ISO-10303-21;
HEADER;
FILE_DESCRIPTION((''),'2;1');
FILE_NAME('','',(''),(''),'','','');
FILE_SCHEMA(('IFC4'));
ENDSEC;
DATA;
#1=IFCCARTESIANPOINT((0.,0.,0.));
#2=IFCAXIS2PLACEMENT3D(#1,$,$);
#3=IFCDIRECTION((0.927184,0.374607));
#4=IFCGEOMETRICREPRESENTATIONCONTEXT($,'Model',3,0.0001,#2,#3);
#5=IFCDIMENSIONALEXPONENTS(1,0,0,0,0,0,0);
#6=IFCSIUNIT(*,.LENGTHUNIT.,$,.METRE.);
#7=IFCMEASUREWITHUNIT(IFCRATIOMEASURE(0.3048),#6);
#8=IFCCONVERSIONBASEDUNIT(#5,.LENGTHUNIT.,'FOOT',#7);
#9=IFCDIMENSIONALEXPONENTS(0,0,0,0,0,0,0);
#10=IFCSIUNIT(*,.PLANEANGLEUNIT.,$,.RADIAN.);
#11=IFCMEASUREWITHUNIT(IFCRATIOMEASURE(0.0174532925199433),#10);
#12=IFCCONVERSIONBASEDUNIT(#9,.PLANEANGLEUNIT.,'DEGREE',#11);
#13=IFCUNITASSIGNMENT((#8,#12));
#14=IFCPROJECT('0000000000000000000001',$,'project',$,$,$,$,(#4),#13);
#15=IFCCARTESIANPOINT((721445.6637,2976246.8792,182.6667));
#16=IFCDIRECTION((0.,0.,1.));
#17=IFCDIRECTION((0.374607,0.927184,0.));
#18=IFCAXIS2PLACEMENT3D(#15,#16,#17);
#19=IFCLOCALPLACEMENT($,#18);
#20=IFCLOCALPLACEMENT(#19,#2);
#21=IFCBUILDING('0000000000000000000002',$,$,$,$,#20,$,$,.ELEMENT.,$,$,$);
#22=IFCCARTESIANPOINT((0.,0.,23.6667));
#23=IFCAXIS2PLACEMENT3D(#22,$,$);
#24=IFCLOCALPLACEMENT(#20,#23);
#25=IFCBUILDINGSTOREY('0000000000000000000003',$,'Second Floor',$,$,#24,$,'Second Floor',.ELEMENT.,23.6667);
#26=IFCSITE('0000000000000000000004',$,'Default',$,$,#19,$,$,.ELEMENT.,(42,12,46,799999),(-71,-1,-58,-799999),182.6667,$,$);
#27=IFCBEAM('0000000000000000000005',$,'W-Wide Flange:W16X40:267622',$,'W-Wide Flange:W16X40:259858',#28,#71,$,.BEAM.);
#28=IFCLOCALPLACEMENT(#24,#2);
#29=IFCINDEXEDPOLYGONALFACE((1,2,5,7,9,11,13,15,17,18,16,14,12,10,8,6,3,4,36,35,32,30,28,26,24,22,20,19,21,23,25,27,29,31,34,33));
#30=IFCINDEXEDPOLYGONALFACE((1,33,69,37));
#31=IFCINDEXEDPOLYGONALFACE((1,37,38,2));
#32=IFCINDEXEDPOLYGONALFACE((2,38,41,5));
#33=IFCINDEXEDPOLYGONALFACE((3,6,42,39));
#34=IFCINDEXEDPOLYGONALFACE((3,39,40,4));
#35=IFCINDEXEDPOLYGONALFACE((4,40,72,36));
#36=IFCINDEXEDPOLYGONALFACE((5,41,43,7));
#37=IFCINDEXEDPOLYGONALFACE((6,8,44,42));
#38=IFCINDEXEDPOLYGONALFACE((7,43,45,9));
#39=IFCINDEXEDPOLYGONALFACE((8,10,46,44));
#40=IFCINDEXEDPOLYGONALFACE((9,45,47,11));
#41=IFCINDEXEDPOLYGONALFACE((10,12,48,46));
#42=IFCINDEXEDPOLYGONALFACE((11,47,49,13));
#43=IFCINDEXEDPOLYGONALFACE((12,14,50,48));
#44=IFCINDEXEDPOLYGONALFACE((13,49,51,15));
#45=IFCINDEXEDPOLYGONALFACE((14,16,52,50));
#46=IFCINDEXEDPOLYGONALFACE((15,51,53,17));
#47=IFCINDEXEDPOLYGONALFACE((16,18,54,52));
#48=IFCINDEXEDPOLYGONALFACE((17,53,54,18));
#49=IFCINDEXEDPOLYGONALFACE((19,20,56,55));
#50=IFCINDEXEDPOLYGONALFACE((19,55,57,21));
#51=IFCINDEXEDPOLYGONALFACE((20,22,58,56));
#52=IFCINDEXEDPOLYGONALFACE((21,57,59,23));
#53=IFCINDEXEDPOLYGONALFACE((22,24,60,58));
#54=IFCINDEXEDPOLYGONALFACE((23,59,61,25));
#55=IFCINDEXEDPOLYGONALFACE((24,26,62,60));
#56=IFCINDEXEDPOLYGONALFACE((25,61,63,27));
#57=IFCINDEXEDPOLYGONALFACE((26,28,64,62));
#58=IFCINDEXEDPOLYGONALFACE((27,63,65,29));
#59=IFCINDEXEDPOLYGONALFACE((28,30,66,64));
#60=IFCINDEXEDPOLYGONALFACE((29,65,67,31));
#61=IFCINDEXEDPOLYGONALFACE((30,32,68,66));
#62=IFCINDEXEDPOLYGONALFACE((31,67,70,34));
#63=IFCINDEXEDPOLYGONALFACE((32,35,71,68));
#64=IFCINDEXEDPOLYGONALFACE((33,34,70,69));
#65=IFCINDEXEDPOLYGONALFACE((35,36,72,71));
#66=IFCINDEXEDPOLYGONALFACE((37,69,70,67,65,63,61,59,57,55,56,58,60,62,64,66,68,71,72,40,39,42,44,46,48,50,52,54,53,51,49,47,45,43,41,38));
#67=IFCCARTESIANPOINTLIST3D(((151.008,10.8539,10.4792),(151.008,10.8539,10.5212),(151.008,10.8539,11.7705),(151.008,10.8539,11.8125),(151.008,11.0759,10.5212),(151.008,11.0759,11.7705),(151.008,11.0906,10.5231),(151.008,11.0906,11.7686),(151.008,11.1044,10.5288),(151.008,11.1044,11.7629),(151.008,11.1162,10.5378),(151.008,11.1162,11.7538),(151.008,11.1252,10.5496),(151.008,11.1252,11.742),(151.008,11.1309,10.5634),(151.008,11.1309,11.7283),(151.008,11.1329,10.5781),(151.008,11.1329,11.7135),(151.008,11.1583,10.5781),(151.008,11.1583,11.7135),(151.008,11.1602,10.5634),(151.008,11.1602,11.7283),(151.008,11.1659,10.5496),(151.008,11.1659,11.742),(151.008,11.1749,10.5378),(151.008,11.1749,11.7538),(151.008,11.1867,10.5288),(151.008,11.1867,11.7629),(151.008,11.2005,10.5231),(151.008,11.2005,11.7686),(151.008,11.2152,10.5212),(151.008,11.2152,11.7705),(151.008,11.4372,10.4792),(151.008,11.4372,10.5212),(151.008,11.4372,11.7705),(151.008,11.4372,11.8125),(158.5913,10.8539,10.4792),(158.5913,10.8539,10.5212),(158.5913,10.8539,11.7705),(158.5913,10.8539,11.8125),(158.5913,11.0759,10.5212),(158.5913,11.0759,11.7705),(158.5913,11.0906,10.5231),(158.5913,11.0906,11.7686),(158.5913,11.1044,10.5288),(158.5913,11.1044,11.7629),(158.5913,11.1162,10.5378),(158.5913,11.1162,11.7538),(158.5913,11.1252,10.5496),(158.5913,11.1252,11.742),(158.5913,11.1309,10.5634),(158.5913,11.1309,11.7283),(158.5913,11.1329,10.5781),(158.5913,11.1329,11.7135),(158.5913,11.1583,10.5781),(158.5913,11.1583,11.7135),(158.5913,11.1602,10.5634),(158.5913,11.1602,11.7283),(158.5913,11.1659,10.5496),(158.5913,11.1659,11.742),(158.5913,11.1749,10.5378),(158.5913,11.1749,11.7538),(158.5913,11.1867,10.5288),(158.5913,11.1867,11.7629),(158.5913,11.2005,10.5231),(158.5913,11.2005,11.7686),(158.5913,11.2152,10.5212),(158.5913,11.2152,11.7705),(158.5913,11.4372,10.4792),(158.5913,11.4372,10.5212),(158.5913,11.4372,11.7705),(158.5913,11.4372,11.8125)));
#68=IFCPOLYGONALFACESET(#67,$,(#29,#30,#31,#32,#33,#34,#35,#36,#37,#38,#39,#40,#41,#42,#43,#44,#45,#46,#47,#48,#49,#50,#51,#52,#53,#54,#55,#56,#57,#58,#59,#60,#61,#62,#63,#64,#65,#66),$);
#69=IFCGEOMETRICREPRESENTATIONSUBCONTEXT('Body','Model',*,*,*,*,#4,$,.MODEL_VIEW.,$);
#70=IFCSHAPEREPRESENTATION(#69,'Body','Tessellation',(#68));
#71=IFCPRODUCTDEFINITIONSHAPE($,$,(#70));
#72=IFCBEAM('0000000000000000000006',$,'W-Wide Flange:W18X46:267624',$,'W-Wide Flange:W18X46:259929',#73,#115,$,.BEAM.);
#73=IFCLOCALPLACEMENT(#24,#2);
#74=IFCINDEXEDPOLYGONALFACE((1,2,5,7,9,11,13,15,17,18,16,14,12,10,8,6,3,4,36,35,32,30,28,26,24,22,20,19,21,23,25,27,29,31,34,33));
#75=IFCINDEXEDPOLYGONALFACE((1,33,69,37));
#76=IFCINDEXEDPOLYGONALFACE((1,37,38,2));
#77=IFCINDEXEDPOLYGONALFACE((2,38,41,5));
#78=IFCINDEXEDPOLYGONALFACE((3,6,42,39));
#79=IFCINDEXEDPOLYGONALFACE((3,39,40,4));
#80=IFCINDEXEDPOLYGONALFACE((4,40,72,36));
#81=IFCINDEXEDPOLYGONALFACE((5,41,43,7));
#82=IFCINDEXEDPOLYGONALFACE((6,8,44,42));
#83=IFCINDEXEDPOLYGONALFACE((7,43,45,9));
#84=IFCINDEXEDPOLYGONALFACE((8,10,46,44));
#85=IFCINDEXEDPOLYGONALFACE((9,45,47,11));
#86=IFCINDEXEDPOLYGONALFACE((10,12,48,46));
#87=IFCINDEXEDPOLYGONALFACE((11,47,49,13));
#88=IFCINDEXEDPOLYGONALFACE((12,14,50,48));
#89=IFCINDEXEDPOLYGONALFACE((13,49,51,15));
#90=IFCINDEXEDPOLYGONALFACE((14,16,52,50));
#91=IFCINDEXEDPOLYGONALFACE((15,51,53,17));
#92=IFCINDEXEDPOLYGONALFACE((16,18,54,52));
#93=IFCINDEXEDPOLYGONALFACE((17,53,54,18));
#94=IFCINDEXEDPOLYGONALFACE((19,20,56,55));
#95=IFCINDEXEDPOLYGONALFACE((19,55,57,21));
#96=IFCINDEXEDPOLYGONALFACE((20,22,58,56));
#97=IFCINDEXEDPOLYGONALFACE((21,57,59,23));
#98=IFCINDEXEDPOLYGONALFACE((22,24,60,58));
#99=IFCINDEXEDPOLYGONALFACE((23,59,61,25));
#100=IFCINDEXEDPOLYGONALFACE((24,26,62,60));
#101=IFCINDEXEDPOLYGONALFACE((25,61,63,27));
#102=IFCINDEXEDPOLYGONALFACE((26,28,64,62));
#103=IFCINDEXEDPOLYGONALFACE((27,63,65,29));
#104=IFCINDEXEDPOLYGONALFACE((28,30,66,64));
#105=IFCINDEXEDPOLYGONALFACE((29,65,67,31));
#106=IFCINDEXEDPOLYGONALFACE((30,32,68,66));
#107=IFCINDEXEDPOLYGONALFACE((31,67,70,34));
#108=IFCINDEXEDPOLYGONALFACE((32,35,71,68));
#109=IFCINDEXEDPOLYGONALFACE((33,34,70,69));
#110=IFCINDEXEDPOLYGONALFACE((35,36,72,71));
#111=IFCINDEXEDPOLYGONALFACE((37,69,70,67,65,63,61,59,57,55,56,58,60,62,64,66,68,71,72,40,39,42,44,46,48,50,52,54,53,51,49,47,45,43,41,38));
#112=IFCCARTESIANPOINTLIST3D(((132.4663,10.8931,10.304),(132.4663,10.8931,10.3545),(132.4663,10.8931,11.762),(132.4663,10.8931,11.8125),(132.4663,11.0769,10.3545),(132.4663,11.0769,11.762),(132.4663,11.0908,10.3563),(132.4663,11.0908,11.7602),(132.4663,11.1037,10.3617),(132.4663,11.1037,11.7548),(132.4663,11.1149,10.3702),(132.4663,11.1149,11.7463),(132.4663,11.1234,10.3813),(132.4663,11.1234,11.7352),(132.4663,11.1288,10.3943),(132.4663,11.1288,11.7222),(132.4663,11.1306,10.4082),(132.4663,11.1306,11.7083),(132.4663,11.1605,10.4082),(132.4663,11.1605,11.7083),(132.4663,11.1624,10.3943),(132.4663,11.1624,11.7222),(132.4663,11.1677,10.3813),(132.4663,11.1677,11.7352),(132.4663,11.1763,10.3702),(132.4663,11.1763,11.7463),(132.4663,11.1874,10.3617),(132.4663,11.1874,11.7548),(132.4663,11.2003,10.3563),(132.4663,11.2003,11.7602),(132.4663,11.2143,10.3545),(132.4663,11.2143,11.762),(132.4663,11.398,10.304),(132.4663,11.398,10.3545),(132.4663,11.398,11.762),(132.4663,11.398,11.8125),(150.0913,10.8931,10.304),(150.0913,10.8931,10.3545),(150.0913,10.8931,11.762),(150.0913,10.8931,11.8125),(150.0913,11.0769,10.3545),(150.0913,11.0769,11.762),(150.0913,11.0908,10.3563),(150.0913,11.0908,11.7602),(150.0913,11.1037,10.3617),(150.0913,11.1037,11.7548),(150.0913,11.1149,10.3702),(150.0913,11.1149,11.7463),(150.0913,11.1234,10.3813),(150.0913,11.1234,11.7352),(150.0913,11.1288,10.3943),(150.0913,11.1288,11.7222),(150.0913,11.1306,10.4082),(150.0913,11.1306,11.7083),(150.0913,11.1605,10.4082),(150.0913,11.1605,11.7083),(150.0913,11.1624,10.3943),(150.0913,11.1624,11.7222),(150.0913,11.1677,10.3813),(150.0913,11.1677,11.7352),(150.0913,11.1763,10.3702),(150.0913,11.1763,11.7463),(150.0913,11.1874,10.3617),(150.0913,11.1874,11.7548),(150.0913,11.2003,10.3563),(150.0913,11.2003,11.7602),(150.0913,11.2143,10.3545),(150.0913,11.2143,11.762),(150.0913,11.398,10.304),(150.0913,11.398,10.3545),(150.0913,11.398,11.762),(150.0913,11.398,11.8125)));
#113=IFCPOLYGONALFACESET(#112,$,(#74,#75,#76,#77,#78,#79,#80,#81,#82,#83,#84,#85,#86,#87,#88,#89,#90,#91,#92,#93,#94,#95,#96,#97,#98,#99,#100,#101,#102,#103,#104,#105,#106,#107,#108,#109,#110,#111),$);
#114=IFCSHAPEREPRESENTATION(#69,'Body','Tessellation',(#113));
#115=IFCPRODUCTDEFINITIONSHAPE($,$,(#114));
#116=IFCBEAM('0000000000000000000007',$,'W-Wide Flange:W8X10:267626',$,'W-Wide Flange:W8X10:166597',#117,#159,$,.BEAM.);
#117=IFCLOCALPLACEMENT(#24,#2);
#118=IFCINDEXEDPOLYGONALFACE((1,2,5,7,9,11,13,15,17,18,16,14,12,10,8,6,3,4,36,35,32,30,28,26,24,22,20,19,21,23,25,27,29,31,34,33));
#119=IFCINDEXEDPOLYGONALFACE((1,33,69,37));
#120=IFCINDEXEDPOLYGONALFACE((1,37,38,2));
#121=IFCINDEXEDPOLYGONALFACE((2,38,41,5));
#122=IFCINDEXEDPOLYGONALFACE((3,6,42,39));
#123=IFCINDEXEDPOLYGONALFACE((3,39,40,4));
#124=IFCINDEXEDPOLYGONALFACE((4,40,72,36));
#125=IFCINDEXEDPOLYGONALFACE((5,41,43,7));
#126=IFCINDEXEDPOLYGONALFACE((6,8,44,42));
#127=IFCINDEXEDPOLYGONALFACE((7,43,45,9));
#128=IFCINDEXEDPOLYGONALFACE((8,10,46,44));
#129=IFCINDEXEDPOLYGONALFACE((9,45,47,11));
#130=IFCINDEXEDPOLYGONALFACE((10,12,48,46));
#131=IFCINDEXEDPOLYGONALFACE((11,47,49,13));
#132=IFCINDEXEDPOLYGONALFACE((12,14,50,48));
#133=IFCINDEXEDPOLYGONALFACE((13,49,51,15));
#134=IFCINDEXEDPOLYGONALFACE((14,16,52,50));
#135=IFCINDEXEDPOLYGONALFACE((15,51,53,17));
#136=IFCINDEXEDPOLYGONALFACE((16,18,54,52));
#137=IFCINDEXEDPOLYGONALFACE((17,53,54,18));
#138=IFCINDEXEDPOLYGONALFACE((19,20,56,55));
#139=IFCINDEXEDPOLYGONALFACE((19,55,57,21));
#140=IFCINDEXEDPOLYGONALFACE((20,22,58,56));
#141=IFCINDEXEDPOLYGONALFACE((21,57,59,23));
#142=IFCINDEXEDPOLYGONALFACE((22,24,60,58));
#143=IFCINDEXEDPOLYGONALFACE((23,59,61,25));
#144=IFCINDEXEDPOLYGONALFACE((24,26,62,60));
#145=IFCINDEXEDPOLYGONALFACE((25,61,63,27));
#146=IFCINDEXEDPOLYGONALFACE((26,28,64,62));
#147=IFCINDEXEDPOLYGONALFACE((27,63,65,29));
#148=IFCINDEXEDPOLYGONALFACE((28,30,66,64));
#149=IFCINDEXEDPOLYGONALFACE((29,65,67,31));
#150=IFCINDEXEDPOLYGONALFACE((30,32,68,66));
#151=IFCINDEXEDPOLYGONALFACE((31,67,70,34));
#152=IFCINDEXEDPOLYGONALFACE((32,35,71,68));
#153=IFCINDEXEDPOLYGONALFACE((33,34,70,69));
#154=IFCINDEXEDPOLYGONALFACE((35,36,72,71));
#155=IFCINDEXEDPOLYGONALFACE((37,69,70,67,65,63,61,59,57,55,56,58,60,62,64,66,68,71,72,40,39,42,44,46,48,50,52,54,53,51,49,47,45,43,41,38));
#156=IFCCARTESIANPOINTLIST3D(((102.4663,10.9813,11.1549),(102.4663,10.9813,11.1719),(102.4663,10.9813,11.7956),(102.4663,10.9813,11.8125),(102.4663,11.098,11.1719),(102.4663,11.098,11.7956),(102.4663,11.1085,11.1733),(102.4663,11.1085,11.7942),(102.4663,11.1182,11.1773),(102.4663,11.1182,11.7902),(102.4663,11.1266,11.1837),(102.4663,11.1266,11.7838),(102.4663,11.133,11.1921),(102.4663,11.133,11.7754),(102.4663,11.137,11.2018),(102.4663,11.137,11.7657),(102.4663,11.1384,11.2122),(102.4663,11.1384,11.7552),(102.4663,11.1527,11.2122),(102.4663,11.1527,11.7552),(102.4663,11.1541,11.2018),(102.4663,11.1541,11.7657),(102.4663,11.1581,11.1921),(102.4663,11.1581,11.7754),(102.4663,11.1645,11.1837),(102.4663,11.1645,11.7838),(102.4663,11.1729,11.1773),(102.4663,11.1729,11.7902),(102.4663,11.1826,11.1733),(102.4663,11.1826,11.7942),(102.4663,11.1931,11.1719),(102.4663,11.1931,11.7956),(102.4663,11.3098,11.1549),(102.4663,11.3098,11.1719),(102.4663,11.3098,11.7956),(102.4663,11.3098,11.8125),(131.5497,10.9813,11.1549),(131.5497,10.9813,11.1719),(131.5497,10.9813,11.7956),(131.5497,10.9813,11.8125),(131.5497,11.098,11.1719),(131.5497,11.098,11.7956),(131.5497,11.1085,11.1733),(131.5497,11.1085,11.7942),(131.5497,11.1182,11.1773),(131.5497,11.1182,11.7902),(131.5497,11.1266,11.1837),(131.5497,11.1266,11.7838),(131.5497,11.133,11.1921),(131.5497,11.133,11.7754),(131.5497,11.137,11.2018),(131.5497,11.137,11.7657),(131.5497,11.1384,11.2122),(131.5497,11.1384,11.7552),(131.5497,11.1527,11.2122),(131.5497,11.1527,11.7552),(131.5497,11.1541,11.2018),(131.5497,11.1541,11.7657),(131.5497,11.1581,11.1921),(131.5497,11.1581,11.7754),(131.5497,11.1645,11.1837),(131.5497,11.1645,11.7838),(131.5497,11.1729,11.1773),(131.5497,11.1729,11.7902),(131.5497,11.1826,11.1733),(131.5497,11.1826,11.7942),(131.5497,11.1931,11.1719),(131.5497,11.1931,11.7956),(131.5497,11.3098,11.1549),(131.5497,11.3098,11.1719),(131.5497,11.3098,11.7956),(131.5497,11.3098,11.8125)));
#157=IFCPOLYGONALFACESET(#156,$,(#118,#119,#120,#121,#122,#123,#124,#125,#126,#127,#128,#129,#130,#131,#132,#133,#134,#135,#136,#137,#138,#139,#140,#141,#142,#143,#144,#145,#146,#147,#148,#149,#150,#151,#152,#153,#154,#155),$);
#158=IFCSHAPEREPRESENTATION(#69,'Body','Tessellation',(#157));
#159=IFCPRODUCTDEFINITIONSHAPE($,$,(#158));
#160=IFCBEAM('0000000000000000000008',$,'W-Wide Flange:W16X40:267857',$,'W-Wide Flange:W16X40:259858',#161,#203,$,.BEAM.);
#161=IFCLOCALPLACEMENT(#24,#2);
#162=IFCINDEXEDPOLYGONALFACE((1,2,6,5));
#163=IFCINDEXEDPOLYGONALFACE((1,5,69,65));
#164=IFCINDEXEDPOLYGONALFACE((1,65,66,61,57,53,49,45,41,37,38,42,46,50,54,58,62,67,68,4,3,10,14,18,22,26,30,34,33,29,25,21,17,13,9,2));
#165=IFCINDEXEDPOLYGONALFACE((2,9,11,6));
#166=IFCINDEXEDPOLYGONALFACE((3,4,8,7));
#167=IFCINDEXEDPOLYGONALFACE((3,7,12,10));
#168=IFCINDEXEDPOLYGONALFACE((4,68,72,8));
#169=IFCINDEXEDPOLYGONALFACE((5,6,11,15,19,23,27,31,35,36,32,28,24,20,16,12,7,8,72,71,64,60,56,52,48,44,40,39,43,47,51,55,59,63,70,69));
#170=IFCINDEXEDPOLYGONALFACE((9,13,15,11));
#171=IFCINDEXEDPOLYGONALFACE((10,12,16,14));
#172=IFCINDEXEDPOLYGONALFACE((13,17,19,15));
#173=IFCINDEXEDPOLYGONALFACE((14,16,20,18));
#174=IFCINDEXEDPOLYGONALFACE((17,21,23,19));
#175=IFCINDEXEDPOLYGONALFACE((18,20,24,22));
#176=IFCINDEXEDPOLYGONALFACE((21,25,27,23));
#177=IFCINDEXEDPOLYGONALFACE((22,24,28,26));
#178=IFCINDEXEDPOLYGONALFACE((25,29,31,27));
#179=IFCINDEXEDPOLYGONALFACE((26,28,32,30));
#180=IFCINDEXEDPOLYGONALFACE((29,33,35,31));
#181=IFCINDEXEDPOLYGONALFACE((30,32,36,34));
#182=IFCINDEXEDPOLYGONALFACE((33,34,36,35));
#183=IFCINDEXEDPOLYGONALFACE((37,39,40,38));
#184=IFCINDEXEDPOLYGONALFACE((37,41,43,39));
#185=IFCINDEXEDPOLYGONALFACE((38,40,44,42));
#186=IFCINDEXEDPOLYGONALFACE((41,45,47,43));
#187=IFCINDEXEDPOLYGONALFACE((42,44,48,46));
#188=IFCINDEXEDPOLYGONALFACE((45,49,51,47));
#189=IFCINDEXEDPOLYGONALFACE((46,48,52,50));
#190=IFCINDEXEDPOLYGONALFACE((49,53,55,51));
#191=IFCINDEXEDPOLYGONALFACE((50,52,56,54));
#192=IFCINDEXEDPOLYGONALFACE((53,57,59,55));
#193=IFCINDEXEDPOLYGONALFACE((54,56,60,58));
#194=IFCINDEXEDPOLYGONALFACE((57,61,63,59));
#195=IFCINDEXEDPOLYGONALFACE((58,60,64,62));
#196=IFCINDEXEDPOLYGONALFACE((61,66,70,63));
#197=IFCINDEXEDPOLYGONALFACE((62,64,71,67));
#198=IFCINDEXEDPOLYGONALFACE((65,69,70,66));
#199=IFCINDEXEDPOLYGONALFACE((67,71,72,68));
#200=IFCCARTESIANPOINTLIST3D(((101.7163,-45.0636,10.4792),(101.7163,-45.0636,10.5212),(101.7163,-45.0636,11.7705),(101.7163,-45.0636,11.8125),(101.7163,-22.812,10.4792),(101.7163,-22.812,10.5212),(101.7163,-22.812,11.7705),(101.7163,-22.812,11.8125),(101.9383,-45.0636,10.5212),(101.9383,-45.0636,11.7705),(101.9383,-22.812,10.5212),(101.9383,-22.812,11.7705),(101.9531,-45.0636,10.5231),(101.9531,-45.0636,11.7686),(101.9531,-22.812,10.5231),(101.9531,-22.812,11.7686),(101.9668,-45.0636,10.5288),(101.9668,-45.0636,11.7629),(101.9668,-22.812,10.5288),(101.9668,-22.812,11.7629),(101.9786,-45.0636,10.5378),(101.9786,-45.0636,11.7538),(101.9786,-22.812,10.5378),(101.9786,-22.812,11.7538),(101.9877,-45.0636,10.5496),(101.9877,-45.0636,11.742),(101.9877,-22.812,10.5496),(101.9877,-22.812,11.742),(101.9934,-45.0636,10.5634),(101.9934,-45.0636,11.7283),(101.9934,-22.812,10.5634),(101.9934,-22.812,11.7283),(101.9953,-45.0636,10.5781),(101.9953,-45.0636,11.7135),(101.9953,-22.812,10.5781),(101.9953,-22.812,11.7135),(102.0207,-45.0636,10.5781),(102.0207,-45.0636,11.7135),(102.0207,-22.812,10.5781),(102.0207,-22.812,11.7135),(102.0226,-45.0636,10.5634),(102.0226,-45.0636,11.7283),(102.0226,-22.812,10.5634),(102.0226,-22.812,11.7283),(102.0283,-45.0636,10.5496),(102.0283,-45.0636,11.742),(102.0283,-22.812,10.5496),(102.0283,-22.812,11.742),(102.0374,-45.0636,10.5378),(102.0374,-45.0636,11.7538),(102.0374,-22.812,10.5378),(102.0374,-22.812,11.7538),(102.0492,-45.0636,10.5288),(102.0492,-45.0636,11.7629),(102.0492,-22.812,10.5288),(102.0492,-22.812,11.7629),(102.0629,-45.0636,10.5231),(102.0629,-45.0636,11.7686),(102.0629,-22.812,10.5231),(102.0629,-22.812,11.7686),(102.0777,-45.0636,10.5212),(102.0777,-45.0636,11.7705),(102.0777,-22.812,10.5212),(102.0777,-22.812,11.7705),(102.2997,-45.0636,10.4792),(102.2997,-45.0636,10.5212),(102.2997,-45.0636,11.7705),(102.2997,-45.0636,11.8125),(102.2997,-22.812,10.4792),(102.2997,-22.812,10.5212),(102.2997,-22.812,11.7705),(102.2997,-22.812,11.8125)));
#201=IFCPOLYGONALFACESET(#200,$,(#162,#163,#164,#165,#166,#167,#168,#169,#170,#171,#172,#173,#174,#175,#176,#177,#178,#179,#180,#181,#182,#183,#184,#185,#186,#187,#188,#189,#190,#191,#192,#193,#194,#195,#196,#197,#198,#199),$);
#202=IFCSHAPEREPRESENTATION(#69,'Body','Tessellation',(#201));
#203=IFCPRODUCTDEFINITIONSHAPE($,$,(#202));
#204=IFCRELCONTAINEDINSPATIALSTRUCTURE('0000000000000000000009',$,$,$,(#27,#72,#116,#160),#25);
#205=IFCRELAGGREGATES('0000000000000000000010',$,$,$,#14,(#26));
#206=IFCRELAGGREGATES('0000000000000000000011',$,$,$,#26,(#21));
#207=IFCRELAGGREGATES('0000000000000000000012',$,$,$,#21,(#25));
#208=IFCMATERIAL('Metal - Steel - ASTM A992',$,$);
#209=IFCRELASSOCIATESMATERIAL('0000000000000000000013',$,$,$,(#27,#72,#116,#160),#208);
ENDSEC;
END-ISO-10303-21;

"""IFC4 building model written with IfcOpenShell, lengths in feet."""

from ifc_helpers import new_model, entity, si_unit, converted_unit, direction, frame, frame_2d, origin, place, context, subcontext, project, spatial, i_section, extrude, material, element, save


model = new_model("IFC4")

# Units and contexts
model_context = context("Model", 3, precision=0.0001, world=origin(), true_north=direction((0.927184, 0.374607)))
body_context = subcontext(model_context, "Body", "Model", "MODEL_VIEW")
ifc_project = project(units=[converted_unit("LENGTHUNIT", "FOOT", entity("IfcRatioMeasure", 0.3048), si_unit("LENGTHUNIT", "METRE"), dimensions=[1, 0, 0, 0, 0, 0, 0]), converted_unit("PLANEANGLEUNIT", "DEGREE", entity("IfcRatioMeasure", 0.0174532925199433), si_unit("PLANEANGLEUNIT", "RADIAN"), dimensions=[0, 0, 0, 0, 0, 0, 0])], contexts=[model_context])

# Site, building, storey
site_placement = place(None, frame((721445.6637, 2976246.8792, 182.6667), z_axis=(0.0, 0.0, 1.0), x_axis=(0.374607, 0.927184, 0.0)))
site = spatial("IfcSite", under=ifc_project, at=site_placement, Name="Default", CompositionType="ELEMENT", RefLatitude=(42, 12, 46, 799999), RefLongitude=(-71, -1, -58, -799999), RefElevation=182.6667)
building_placement = place(site_placement, origin())
building = spatial("IfcBuilding", under=site, at=building_placement, CompositionType="ELEMENT")
storey_placement = place(building_placement, frame((0.0, 0.0, 23.6667)))
storey = spatial("IfcBuildingStorey", under=building, at=storey_placement, Name="Second Floor", LongName="Second Floor", CompositionType="ELEMENT", Elevation=23.6667)

# Shared definitions
ifc_material_1 = material(Name="Metal - Steel - ASTM A992")

# Beams
beam_1_placement = place(storey_placement, frame((150.5497, 11.1456, 11.8125)))
element("IfcBeam", 1, at=beam_1_placement, inside=storey, material=ifc_material_1, Name="W-Wide Flange:W16X40:267622", ObjectType="W-Wide Flange:W16X40:259858", PredefinedType="BEAM", context=body_context, shape_type="SweptSolid", body=[
    extrude(i_section(OverallWidth=0.5833, OverallDepth=1.3333, WebThickness=0.0254, FlangeThickness=0.042, FilletRadius=0.057, at=frame_2d((0.0, 0.0), x_axis=(0.0, 1.0))), frame((0.4583, 0.0, -0.6667), z_axis=(1.0, 0.0, 0.0), x_axis=(0.0, 0.0, -1.0)), (0.0, 0.0, 1.0), 7.5833),
])
beam_2_placement = place(storey_placement, frame((132.008, 11.1456, 11.8125)))
element("IfcBeam", 2, at=beam_2_placement, inside=storey, material=ifc_material_1, Name="W-Wide Flange:W18X46:267624", ObjectType="W-Wide Flange:W18X46:259929", PredefinedType="BEAM", context=body_context, shape_type="SweptSolid", body=[
    extrude(i_section(OverallWidth=0.5049, OverallDepth=1.5085, WebThickness=0.0299, FlangeThickness=0.0505, FilletRadius=0.0537, at=frame_2d((0.0, 0.0), x_axis=(0.0, 1.0))), frame((0.4583, 0.0, -0.7542), z_axis=(1.0, 0.0, 0.0), x_axis=(0.0, 0.0, -1.0)), (0.0, 0.0, 1.0), 17.625),
])
beam_3_placement = place(storey_placement, frame((132.008, 11.1456, 11.8125), z_axis=(0.0, 0.0, 1.0), x_axis=(-1.0, 0.0, 0.0)))
element("IfcBeam", 3, at=beam_3_placement, inside=storey, material=ifc_material_1, Name="W-Wide Flange:W8X10:267626", ObjectType="W-Wide Flange:W8X10:166597", PredefinedType="BEAM", context=body_context, shape_type="SweptSolid", body=[
    extrude(i_section(OverallWidth=0.3285, OverallDepth=0.6576, WebThickness=0.0143, FlangeThickness=0.0169, FilletRadius=0.0404, at=frame_2d((0.0, 0.0), x_axis=(0.0, 1.0))), frame((0.4583, 0.0, -0.3288), z_axis=(1.0, 0.0, 0.0), x_axis=(0.0, 0.0, -1.0)), (0.0, 0.0, 1.0), 29.0833),
])
beam_4_placement = place(storey_placement, frame((102.008, -22.3544, 11.8125), z_axis=(0.0, 0.0, 1.0), x_axis=(0.0, -1.0, 0.0)))
element("IfcBeam", 4, at=beam_4_placement, inside=storey, material=ifc_material_1, Name="W-Wide Flange:W16X40:267857", ObjectType="W-Wide Flange:W16X40:259858", PredefinedType="BEAM", context=body_context, shape_type="SweptSolid", body=[
    extrude(i_section(OverallWidth=0.5833, OverallDepth=1.3333, WebThickness=0.0254, FlangeThickness=0.042, FilletRadius=0.057, at=frame_2d((0.0, 0.0), x_axis=(0.0, 1.0))), frame((0.4575, 0.0, -0.6667), z_axis=(1.0, 0.0, 0.0), x_axis=(0.0, 0.0, -1.0)), (0.0, 0.0, 1.0), 22.2516),
])

save(model, "model.ifc")
